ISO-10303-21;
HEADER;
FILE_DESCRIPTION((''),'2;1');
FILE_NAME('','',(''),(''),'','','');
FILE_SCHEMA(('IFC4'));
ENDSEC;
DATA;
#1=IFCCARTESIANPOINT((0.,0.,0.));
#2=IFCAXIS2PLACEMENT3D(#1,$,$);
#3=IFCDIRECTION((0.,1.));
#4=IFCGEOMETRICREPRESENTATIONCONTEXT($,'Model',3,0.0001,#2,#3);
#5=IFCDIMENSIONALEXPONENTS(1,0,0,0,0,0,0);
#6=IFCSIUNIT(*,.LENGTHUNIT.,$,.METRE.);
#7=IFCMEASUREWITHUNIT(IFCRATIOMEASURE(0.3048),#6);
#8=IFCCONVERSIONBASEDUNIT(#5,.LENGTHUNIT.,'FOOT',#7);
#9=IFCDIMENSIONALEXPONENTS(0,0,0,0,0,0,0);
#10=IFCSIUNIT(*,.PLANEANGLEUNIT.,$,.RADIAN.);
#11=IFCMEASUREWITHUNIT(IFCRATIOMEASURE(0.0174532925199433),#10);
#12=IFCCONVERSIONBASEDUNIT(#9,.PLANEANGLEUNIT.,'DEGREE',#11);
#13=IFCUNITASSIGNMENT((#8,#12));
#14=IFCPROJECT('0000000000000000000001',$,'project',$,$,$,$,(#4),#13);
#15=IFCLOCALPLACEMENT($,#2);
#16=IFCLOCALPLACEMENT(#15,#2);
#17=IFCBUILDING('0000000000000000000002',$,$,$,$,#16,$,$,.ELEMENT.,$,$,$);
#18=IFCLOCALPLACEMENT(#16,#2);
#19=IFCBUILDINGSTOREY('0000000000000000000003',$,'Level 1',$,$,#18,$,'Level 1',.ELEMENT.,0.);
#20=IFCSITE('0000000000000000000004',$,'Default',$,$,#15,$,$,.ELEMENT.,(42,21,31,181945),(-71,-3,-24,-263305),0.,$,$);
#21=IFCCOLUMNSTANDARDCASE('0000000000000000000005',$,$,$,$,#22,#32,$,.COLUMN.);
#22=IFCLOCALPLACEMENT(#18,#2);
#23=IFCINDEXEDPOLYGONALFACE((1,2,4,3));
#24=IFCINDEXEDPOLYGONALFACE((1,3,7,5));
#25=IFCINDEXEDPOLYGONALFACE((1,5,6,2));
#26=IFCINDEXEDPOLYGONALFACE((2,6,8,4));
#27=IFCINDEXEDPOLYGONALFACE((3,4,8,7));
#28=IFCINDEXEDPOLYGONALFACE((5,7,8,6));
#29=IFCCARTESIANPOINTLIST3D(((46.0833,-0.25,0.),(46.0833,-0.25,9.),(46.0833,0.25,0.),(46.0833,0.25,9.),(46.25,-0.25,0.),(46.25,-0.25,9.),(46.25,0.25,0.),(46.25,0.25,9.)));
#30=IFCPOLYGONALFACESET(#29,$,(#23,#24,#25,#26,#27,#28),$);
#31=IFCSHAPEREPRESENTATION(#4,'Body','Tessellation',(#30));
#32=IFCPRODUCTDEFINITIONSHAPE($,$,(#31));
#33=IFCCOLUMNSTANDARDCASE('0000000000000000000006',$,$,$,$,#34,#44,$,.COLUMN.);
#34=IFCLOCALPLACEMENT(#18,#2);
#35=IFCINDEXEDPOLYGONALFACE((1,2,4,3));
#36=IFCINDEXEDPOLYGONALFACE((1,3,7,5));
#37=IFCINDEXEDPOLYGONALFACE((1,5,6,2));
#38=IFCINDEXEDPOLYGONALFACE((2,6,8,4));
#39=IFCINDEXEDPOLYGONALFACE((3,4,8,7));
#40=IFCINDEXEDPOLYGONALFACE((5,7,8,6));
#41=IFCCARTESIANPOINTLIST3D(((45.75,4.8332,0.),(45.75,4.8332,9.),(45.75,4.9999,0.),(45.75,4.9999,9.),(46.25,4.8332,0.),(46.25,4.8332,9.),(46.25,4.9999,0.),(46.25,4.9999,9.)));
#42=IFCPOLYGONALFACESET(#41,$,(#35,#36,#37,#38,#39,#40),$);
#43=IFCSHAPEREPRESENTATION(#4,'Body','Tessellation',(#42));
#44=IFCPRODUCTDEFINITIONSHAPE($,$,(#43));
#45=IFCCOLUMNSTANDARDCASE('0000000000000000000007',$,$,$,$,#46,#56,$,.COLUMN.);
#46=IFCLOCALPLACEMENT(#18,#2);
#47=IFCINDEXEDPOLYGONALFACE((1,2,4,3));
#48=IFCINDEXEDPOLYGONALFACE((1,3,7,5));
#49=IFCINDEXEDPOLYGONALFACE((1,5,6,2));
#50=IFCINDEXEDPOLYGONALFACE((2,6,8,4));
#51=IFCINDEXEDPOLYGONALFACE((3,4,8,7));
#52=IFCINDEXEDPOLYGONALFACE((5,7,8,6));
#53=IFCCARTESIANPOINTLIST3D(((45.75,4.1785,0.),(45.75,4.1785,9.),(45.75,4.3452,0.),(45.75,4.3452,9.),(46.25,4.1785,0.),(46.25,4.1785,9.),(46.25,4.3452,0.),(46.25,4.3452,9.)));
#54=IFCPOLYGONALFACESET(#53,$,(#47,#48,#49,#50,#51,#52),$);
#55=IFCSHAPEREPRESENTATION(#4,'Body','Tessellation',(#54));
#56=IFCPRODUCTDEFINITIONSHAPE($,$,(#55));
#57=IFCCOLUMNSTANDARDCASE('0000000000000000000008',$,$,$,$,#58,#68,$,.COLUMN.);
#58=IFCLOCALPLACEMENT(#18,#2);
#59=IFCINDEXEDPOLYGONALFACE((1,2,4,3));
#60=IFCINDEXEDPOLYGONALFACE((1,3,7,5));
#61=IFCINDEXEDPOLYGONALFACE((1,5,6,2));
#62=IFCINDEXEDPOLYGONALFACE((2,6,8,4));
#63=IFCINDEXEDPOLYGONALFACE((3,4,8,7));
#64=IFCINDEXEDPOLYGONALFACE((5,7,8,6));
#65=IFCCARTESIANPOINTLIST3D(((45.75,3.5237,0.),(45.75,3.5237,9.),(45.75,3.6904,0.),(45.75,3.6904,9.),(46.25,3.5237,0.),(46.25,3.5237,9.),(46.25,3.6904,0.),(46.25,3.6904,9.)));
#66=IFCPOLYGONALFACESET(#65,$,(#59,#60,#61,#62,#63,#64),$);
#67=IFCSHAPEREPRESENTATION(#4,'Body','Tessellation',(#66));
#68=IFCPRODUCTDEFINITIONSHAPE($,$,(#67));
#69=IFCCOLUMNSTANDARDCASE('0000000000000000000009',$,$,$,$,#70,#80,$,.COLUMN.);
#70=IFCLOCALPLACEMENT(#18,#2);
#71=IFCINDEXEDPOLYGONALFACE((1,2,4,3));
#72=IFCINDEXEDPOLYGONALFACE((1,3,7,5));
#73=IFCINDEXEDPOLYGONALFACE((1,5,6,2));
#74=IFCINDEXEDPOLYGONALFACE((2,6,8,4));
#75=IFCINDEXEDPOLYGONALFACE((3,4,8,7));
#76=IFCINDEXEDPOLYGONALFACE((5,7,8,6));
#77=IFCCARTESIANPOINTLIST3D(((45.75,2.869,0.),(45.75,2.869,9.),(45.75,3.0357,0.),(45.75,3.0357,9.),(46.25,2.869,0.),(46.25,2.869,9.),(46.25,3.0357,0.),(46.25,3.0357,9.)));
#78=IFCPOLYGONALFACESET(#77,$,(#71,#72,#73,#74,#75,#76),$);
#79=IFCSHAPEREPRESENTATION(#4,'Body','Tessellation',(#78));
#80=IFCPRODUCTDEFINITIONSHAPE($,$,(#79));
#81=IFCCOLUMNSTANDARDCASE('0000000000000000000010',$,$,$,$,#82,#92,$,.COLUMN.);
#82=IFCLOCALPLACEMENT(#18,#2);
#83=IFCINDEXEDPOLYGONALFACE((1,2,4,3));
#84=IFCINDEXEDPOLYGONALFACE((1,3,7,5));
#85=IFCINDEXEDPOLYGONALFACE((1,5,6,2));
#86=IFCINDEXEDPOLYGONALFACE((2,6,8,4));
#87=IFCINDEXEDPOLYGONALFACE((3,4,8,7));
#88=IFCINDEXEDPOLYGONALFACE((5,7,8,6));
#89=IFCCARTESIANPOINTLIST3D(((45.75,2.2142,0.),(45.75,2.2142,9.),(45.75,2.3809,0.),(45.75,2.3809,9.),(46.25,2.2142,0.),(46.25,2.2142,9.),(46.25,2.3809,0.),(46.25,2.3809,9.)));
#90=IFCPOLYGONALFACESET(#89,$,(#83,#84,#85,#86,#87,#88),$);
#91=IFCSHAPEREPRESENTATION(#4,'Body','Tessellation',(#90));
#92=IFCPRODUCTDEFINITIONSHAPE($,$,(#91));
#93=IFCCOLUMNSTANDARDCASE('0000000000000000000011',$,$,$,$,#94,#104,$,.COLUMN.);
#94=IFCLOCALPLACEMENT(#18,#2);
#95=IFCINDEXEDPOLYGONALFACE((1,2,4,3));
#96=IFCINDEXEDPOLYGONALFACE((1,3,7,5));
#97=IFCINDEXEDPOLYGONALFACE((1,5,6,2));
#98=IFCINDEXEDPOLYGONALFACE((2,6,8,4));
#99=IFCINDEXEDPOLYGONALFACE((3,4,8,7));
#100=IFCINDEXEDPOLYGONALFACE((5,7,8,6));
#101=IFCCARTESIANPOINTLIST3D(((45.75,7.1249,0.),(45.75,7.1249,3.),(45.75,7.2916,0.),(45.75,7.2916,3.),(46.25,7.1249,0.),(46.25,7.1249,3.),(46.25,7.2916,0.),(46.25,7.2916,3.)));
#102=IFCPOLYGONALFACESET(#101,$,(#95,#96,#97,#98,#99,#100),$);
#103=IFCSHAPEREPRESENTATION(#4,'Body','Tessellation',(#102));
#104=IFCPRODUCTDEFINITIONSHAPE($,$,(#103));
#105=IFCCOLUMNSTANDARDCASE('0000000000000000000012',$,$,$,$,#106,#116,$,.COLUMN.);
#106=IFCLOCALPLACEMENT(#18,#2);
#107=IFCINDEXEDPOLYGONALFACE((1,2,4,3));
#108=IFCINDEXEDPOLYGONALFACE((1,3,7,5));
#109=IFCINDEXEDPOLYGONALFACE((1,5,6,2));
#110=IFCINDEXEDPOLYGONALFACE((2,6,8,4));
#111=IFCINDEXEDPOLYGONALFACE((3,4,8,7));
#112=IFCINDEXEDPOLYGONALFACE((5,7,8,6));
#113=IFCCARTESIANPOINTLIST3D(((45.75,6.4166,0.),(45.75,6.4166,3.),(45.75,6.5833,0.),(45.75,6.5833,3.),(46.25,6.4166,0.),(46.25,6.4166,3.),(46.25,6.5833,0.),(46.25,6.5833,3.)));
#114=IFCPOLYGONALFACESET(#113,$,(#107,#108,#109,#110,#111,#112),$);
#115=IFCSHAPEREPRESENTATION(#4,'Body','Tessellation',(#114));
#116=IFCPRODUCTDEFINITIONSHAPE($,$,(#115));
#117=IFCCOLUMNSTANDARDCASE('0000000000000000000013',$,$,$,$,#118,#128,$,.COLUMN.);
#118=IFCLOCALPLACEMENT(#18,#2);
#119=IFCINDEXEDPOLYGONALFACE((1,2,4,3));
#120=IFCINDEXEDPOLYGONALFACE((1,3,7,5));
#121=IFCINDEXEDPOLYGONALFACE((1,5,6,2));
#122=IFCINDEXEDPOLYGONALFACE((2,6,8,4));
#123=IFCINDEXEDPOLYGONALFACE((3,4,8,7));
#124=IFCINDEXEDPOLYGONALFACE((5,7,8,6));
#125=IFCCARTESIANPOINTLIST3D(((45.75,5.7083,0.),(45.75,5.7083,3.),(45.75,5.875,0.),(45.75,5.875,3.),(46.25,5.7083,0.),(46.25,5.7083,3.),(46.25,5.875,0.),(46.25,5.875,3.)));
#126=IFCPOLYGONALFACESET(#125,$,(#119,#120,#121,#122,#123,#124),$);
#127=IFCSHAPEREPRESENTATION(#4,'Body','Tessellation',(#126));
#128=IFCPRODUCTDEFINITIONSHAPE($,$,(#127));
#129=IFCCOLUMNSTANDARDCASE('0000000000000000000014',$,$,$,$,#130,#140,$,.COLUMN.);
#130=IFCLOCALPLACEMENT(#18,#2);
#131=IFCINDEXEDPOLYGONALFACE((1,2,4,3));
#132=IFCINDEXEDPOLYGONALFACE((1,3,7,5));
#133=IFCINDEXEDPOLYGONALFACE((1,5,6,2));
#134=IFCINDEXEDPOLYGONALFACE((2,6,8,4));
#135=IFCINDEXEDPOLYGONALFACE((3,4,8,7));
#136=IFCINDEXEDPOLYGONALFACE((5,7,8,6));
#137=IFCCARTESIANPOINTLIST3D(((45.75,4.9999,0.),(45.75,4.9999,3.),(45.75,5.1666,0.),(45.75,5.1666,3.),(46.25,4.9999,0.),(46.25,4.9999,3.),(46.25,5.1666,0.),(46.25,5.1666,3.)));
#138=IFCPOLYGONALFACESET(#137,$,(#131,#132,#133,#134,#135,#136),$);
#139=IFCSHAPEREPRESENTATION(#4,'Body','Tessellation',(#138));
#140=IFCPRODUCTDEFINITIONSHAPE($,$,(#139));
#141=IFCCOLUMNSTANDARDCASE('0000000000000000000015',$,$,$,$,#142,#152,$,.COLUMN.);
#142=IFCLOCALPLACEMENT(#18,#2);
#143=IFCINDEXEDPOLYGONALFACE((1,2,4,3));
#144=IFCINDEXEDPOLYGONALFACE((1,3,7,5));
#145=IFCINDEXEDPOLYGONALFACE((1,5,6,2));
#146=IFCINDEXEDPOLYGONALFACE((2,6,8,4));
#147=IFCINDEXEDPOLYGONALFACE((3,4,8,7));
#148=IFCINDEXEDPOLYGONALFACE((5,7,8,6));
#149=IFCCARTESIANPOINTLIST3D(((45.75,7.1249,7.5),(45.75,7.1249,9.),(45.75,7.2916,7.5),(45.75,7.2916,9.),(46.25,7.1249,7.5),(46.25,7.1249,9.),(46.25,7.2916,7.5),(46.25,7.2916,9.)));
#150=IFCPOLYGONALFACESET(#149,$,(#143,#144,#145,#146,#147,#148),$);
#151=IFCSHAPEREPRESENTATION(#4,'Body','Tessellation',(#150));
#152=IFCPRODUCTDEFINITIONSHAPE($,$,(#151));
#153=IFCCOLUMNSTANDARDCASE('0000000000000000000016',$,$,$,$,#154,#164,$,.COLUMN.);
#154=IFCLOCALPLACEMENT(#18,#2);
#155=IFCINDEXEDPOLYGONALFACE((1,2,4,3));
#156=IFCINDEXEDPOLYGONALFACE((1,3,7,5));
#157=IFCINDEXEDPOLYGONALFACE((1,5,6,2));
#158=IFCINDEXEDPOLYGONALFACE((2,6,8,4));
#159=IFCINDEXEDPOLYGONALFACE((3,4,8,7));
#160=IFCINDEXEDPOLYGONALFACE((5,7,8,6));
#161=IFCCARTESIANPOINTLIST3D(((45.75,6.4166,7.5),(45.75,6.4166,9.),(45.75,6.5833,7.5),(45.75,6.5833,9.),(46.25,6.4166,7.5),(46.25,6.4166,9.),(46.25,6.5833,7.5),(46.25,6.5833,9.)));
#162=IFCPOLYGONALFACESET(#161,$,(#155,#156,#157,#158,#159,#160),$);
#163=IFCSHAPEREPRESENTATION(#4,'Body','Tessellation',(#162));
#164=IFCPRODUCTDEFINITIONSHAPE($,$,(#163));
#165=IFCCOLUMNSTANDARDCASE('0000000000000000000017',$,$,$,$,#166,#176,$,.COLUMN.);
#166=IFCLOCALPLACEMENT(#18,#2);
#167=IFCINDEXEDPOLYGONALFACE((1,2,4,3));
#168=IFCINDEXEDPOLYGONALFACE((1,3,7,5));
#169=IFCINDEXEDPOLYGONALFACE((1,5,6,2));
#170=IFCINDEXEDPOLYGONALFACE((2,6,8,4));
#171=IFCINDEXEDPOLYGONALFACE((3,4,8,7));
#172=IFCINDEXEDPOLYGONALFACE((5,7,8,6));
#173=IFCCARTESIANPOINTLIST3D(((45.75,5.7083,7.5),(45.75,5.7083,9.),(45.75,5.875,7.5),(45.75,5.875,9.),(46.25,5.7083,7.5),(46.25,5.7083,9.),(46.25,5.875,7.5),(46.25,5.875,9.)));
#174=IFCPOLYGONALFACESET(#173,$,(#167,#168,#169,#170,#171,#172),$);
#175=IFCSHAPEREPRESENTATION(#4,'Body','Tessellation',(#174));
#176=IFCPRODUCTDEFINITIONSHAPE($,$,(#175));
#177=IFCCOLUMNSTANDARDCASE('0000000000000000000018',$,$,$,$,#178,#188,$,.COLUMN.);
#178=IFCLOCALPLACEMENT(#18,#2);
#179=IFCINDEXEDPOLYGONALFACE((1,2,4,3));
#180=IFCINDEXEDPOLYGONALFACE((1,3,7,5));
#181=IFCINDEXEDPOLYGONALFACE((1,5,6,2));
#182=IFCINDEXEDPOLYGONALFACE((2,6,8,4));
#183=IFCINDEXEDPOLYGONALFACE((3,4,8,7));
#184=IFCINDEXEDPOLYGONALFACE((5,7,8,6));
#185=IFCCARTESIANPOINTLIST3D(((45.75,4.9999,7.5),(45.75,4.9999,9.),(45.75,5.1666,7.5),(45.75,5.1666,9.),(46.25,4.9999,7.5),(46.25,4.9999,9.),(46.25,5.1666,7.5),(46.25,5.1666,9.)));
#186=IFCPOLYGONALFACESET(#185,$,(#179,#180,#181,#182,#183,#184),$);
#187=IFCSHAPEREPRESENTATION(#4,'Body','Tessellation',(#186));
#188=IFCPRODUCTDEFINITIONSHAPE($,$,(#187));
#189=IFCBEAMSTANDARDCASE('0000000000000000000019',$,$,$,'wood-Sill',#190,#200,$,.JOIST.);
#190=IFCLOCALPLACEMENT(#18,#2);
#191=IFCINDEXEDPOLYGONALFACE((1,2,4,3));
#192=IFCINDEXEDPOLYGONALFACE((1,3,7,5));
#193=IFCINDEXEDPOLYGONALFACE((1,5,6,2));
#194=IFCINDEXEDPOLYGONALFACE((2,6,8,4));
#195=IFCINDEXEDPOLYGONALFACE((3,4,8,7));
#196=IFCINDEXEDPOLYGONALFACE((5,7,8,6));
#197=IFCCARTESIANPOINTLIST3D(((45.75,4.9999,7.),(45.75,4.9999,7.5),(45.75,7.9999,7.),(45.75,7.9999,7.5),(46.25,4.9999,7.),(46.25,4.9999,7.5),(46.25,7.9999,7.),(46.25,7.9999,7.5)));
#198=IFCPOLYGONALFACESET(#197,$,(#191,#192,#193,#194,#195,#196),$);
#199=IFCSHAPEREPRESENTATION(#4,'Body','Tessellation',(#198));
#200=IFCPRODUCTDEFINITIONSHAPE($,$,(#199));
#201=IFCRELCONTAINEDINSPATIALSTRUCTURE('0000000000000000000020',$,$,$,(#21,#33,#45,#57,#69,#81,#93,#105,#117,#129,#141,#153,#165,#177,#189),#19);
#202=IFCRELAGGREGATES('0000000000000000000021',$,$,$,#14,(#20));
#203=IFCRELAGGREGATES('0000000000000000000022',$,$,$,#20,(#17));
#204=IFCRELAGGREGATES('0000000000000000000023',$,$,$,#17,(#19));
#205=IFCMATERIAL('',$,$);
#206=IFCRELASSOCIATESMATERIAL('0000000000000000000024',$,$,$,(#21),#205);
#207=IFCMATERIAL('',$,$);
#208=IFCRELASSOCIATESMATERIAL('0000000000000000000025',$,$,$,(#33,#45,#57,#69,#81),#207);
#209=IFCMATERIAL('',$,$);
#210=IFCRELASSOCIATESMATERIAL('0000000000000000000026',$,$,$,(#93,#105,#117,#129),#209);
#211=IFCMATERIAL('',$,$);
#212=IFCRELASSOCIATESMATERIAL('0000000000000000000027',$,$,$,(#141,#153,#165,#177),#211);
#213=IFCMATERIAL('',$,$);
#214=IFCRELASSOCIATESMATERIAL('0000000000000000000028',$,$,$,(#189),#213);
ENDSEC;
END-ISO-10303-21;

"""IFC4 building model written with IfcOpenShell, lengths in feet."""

from ifc_helpers import new_model, entity, si_unit, converted_unit, direction, frame, origin, place, context, project, spatial, rectangle, extrude, material, element, save


model = new_model("IFC4")

# Units and contexts
model_context = context("Model", 3, precision=0.0001, world=origin(), true_north=direction((0.0, 1.0)))
ifc_project = project(units=[converted_unit("LENGTHUNIT", "FOOT", entity("IfcRatioMeasure", 0.3048), si_unit("LENGTHUNIT", "METRE"), dimensions=[1, 0, 0, 0, 0, 0, 0]), converted_unit("PLANEANGLEUNIT", "DEGREE", entity("IfcRatioMeasure", 0.0174532925199433), si_unit("PLANEANGLEUNIT", "RADIAN"), dimensions=[0, 0, 0, 0, 0, 0, 0])], contexts=[model_context])

# Site, building, storey
site_placement = place(None, origin())
site = spatial("IfcSite", under=ifc_project, at=site_placement, Name="Default", CompositionType="ELEMENT", RefLatitude=(42, 21, 31, 181945), RefLongitude=(-71, -3, -24, -263305), RefElevation=0.0)
building_placement = place(site_placement, origin())
building = spatial("IfcBuilding", under=site, at=building_placement, CompositionType="ELEMENT")
storey_placement = place(building_placement, origin())
storey = spatial("IfcBuildingStorey", under=building, at=storey_placement, Name="Level 1", LongName="Level 1", CompositionType="ELEMENT", Elevation=0.0)

# Columns
ifc_material_1 = material(Name="")
placement_1 = place(storey_placement, frame((46.25, 0.0, 0.0), z_axis=(0.0, 0.0, 1.0), x_axis=(-1.0, 0.0, 0.0)))
column_placement = place(placement_1, frame((0.0833, 0.0, 0.0), z_axis=(0.0, 0.0, 1.0), x_axis=(1.0, 0.0, 0.0)))
element("IfcColumnStandardCase", 1, at=column_placement, inside=storey, material=ifc_material_1, PredefinedType="COLUMN", context=model_context, shape_type="SweptSolid", body=[
    extrude(rectangle(XDim=0.1667, YDim=0.5), origin(), (0.0, 0.0, 1.0), 9.0),
])
ifc_material_2 = material(Name="")
placement_2 = place(storey_placement, frame((46.0, 46.25, 0.0), z_axis=(0.0, 0.0, 1.0), x_axis=(0.0, -1.0, 0.0)))
for number, where, z_axis, x_axis in (
    (2, (41.3335, 0.0, 0.0), (0.0, 0.0, 1.0), (1.0, 0.0, 0.0)),
    (3, (41.9882, 0.0, 0.0), (0.0, 0.0, 1.0), (1.0, 0.0, 0.0)),
    (4, (42.643, 0.0, 0.0), (0.0, 0.0, 1.0), (1.0, 0.0, 0.0)),
    (5, (43.2977, 0.0, 0.0), (0.0, 0.0, 1.0), (1.0, 0.0, 0.0)),
    (6, (43.9525, 0.0, 0.0), (0.0, 0.0, 1.0), (1.0, 0.0, 0.0)),
):
    element("IfcColumnStandardCase", number, at=place(placement_2, frame(where, z_axis=z_axis, x_axis=x_axis)), inside=storey, material=ifc_material_2, PredefinedType="COLUMN", context=model_context, shape_type="SweptSolid", body=[
        extrude(rectangle(XDim=0.1667, YDim=0.5), origin(), (0.0, 0.0, 1.0), 9.0),
    ])
ifc_material_3 = material(Name="")
for number, where, z_axis, x_axis in (
    (7, (39.0418, 0.0, 0.0), (0.0, 0.0, 1.0), (1.0, 0.0, 0.0)),
    (8, (39.7501, 0.0, 0.0), (0.0, 0.0, 1.0), (1.0, 0.0, 0.0)),
    (9, (40.4584, 0.0, 0.0), (0.0, 0.0, 1.0), (1.0, 0.0, 0.0)),
    (10, (41.1668, 0.0, 0.0), (0.0, 0.0, 1.0), (1.0, 0.0, 0.0)),
):
    element("IfcColumnStandardCase", number, at=place(placement_2, frame(where, z_axis=z_axis, x_axis=x_axis)), inside=storey, material=ifc_material_3, PredefinedType="COLUMN", context=model_context, shape_type="SweptSolid", body=[
        extrude(rectangle(XDim=0.1667, YDim=0.5), origin(), (0.0, 0.0, 1.0), 3.0),
    ])
ifc_material_4 = material(Name="")
for number, where, z_axis, x_axis in (
    (11, (39.0418, 0.0, 7.5), (0.0, 0.0, 1.0), (1.0, 0.0, 0.0)),
    (12, (39.7501, 0.0, 7.5), (0.0, 0.0, 1.0), (1.0, 0.0, 0.0)),
    (13, (40.4584, 0.0, 7.5), (0.0, 0.0, 1.0), (1.0, 0.0, 0.0)),
    (14, (41.1668, 0.0, 7.5), (0.0, 0.0, 1.0), (1.0, 0.0, 0.0)),
):
    element("IfcColumnStandardCase", number, at=place(placement_2, frame(where, z_axis=z_axis, x_axis=x_axis)), inside=storey, material=ifc_material_4, PredefinedType="COLUMN", context=model_context, shape_type="SweptSolid", body=[
        extrude(rectangle(XDim=0.1667, YDim=0.5), origin(), (0.0, 0.0, 1.0), 1.5),
    ])

# Beam
ifc_material_5 = material(Name="")
for number, where, z_axis, x_axis in (
    (15, (39.7501, 0.0, 7.0), (0.0, 0.0, 1.0), (1.0, 0.0, 0.0)),
):
    element("IfcBeamStandardCase", number, at=place(placement_2, frame(where, z_axis=z_axis, x_axis=x_axis)), inside=storey, material=ifc_material_5, ObjectType="wood-Sill", PredefinedType="JOIST", context=model_context, shape_type="SweptSolid", body=[
        extrude(rectangle(XDim=3.0, YDim=0.5), origin(), (0.0, 0.0, 1.0), 0.5),
    ])

save(model, "model.ifc")
